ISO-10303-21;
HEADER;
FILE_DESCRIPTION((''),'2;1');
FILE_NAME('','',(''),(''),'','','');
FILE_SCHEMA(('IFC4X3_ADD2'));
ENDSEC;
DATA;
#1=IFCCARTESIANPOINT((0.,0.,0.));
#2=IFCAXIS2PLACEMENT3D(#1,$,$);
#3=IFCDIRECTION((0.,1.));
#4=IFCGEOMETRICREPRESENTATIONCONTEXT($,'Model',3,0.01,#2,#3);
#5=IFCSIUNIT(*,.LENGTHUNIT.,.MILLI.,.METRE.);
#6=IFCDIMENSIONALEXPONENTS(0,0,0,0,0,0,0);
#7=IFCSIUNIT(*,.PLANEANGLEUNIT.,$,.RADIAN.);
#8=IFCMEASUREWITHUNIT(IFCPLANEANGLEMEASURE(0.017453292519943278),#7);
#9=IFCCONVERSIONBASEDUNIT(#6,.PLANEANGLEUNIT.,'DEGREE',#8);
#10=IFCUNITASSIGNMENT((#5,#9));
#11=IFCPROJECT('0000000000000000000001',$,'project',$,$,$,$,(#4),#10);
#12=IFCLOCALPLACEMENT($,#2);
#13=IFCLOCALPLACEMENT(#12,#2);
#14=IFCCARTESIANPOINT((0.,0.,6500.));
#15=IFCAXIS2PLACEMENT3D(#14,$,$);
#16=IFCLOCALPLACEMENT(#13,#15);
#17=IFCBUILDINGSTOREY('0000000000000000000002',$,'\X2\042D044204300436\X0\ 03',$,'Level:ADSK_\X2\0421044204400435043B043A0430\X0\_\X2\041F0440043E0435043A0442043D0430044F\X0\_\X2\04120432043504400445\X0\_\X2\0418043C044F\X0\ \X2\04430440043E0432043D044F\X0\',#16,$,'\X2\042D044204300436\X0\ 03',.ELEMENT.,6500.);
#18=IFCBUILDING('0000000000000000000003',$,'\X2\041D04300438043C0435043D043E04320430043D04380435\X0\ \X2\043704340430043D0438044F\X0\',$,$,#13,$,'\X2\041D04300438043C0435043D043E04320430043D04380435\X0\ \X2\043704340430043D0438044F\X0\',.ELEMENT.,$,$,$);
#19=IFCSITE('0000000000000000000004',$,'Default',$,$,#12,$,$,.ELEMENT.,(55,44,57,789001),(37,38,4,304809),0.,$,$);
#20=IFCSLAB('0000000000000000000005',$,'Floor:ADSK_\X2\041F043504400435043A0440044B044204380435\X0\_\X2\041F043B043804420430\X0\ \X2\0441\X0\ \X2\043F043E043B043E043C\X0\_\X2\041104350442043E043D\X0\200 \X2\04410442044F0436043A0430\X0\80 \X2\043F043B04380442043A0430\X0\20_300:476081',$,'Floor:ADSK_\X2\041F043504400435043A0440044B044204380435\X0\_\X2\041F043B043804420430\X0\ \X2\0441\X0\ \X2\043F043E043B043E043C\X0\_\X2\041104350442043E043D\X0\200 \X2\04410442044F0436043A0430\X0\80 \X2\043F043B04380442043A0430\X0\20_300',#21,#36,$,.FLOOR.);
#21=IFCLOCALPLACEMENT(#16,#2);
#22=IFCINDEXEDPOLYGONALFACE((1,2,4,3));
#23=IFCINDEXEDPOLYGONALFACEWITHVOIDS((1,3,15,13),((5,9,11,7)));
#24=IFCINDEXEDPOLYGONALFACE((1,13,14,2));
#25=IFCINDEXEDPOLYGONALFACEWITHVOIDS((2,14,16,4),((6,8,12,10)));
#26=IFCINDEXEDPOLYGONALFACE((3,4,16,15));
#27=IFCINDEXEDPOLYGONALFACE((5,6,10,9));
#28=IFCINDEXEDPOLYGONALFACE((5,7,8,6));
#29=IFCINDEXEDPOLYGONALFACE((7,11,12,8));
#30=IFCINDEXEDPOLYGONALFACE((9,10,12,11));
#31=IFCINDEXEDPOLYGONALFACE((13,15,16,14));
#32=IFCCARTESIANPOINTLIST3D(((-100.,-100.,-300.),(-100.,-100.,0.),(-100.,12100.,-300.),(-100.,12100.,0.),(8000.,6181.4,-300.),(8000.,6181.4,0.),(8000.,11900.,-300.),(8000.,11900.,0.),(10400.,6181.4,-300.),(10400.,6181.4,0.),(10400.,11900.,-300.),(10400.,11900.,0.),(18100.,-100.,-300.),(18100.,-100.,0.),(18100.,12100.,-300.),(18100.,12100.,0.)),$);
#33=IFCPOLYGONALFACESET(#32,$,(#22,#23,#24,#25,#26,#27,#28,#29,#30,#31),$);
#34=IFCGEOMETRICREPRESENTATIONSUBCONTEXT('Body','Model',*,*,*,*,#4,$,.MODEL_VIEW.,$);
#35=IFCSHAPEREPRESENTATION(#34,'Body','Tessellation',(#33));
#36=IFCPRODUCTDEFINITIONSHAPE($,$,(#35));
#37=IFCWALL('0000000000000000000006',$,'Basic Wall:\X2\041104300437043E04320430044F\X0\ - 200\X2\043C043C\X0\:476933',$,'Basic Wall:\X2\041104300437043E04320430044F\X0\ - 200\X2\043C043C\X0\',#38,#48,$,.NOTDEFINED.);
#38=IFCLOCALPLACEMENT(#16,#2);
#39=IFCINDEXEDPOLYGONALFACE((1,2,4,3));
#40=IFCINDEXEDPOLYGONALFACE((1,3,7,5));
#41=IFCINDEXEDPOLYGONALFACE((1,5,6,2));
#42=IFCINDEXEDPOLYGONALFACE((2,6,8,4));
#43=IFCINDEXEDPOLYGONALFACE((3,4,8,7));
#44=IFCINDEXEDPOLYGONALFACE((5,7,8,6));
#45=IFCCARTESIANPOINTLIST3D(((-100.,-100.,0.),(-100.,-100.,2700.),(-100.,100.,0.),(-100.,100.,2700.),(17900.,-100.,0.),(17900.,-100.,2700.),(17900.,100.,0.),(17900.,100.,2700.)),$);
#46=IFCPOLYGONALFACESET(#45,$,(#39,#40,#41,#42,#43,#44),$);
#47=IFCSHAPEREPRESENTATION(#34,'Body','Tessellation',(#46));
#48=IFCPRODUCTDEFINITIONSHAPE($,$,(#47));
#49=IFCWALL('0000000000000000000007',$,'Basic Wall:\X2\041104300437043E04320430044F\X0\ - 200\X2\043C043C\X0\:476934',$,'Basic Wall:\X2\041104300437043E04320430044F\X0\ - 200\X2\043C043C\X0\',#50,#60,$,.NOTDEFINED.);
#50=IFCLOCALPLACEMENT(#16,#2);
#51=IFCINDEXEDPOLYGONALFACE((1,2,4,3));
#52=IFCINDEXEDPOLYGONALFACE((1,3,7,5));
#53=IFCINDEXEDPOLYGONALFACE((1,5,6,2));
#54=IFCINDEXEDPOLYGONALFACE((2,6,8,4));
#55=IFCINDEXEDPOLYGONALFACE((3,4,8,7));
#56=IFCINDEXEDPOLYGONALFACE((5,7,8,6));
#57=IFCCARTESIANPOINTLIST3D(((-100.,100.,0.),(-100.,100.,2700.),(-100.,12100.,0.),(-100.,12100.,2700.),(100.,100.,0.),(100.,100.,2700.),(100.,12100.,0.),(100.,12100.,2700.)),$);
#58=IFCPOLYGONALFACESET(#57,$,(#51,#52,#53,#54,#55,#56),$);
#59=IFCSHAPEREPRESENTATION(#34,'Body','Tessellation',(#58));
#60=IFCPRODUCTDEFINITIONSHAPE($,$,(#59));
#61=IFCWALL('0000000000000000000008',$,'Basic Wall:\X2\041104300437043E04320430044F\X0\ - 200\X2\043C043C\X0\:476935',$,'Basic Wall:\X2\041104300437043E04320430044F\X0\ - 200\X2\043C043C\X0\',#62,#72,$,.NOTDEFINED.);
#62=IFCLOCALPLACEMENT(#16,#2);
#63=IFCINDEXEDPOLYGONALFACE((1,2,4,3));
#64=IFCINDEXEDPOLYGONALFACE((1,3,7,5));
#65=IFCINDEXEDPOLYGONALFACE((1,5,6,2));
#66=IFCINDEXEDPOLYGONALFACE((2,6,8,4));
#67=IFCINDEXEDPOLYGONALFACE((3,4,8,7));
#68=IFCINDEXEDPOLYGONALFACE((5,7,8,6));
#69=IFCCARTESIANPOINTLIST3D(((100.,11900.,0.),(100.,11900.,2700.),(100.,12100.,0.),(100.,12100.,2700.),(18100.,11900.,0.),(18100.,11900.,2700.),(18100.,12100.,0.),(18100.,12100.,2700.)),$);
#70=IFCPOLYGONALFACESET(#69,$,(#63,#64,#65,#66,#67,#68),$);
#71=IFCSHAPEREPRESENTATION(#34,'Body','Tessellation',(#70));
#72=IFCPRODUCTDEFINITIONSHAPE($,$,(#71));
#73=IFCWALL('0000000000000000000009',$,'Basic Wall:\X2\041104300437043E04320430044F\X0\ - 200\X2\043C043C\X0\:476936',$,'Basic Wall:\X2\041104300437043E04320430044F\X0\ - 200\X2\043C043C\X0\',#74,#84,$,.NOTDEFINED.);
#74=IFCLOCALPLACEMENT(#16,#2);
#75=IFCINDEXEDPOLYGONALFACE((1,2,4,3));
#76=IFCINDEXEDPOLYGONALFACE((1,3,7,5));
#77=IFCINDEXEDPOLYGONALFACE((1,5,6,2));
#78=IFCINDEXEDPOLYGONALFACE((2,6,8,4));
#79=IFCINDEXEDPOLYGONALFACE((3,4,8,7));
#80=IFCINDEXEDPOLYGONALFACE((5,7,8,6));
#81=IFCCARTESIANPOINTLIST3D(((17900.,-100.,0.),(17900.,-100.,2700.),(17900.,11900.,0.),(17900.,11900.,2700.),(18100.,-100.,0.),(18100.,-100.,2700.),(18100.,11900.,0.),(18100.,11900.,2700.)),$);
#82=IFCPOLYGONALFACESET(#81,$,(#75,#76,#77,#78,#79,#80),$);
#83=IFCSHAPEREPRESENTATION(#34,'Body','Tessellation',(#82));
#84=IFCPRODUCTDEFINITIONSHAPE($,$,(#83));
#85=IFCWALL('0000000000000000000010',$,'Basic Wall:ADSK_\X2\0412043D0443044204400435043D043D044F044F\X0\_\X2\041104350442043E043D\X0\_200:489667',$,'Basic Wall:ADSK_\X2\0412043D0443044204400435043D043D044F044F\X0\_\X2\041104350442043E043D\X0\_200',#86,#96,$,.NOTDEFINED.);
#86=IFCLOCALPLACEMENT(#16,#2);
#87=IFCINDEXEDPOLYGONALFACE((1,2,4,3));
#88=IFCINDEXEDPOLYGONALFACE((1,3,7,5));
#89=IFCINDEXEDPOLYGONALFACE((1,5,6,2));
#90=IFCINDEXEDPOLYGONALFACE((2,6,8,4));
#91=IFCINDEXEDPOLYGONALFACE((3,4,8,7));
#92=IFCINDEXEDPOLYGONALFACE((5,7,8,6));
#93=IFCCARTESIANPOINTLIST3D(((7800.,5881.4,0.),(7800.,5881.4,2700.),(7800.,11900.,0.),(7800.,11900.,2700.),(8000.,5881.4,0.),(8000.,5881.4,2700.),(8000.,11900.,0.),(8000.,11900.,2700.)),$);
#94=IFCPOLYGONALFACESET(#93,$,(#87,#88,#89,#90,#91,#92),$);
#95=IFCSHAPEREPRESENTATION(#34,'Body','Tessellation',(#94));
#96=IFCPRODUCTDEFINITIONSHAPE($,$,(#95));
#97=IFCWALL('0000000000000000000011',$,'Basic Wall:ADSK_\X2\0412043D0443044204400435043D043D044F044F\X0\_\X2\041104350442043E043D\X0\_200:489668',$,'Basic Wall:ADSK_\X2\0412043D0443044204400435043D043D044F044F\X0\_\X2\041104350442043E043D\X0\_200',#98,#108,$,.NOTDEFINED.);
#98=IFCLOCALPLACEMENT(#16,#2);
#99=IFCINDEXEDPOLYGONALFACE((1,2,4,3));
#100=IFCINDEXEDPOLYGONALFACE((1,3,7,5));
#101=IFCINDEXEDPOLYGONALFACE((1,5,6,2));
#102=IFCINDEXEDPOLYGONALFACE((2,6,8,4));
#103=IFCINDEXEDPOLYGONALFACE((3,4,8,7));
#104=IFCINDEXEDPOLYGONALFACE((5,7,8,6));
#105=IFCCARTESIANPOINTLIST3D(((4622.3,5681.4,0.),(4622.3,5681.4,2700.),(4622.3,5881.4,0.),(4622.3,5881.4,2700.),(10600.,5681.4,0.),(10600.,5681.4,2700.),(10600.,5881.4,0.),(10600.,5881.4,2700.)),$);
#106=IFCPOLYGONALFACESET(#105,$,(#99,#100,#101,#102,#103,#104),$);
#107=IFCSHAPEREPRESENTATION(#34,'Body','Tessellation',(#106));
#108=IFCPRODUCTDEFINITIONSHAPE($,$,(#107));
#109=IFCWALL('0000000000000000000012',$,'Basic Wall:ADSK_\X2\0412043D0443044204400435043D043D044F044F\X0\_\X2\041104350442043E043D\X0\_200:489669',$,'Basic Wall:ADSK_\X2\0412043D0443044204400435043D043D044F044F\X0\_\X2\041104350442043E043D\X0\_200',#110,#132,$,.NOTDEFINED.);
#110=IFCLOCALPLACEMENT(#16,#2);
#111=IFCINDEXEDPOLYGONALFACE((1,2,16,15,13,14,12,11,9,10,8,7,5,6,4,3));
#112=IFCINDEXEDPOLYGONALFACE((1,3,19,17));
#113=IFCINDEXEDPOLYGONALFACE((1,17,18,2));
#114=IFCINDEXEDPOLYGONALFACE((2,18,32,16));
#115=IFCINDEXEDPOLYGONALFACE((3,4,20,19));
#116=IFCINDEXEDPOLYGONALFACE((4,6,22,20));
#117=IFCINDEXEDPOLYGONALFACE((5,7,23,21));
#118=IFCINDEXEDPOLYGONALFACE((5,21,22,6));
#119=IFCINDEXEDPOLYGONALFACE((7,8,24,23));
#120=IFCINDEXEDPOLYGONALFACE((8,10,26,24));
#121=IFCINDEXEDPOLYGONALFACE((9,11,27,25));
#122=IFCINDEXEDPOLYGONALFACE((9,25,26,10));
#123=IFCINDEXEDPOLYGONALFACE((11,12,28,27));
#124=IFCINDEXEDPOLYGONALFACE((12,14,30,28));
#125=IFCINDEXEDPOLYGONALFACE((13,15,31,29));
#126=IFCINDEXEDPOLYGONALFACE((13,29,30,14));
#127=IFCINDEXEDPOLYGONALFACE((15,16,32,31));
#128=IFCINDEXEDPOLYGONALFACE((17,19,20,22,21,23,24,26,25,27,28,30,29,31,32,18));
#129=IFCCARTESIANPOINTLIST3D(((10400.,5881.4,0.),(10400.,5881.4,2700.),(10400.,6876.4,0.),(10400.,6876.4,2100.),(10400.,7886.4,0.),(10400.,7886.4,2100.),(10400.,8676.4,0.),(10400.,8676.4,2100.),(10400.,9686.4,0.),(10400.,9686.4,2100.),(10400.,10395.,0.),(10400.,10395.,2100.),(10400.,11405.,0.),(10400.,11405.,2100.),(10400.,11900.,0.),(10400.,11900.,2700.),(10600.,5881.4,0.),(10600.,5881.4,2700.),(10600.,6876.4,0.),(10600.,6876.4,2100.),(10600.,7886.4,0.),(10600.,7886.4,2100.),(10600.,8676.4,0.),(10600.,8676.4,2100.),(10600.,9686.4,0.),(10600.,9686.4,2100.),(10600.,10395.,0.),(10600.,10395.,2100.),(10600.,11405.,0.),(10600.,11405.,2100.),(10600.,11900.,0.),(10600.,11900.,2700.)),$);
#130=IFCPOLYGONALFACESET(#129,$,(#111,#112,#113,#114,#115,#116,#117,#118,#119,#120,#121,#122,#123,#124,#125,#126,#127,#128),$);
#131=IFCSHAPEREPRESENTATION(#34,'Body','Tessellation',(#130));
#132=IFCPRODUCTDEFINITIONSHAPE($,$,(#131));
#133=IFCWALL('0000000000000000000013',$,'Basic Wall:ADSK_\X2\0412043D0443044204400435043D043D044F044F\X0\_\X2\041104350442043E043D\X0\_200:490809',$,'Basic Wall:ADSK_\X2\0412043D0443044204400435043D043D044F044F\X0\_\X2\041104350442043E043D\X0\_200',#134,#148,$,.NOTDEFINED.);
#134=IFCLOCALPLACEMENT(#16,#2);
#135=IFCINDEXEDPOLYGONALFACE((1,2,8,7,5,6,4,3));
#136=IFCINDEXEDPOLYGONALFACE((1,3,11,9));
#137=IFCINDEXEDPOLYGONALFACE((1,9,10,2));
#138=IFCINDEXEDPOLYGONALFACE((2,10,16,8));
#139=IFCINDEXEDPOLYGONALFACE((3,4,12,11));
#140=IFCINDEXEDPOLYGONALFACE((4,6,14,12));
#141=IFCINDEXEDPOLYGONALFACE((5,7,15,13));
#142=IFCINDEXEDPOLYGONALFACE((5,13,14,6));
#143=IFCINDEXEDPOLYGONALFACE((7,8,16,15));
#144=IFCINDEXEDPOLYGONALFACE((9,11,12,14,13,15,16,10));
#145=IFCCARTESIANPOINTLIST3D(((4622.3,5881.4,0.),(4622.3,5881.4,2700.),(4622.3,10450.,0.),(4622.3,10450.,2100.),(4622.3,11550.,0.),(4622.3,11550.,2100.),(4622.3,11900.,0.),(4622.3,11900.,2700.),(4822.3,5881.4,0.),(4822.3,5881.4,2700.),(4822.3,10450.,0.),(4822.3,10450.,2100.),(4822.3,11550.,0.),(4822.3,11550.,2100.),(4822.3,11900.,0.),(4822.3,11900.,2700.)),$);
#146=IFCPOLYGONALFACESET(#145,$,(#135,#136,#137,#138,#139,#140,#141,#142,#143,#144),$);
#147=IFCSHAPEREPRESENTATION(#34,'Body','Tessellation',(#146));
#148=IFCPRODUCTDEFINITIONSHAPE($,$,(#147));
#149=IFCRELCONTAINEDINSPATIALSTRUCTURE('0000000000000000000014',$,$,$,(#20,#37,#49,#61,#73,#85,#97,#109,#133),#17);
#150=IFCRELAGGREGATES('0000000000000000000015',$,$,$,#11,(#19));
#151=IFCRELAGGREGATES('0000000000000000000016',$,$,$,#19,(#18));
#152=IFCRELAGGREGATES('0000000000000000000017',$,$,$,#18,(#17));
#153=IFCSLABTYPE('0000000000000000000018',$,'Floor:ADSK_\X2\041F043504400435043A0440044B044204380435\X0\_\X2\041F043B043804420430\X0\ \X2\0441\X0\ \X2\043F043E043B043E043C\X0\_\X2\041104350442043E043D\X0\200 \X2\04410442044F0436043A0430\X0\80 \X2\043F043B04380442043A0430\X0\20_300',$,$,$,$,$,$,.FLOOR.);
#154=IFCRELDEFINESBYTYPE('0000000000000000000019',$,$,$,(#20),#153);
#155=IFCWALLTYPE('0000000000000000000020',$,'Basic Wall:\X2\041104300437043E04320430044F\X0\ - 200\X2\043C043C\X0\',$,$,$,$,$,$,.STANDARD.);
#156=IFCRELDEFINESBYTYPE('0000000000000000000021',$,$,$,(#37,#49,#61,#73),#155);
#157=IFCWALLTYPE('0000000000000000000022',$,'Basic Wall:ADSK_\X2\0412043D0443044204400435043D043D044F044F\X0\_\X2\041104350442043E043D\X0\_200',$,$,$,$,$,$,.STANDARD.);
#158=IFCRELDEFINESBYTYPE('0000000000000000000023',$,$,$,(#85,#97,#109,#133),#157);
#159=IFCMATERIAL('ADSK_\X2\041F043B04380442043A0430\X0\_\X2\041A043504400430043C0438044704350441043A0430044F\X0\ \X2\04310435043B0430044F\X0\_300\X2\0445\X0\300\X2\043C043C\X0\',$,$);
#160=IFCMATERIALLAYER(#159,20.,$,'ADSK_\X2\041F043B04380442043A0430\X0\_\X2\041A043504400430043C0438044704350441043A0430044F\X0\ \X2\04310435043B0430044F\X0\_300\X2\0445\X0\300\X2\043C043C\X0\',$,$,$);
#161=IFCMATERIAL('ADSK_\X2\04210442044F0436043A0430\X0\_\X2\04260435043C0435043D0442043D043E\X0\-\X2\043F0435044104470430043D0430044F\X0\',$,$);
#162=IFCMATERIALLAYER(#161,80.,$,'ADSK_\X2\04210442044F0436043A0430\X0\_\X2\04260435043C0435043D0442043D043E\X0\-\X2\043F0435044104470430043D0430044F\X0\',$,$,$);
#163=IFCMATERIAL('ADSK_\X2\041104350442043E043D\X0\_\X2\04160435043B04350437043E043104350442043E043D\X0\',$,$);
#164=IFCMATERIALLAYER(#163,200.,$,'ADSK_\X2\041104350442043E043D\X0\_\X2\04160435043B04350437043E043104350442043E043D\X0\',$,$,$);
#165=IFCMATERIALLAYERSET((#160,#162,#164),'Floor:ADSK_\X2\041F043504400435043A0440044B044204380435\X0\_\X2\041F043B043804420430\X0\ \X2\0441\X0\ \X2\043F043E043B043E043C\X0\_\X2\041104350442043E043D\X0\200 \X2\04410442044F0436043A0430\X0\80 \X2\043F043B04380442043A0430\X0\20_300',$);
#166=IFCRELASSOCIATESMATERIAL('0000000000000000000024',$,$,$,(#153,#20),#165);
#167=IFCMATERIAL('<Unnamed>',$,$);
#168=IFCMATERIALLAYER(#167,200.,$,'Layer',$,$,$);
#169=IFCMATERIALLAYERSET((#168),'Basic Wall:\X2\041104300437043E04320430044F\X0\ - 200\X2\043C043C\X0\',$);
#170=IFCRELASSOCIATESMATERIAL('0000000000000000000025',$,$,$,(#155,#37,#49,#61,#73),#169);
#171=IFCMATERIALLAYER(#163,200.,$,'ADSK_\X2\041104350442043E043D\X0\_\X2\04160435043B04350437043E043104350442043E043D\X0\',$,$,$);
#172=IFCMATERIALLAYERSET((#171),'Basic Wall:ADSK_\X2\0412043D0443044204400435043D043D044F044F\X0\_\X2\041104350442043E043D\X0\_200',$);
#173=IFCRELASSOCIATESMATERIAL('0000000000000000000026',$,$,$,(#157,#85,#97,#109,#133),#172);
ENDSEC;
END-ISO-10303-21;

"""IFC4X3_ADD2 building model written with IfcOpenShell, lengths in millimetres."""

from ifc_helpers import new_model, entity, si_unit, converted_unit, direction, frame, frame_2d, origin, origin_2d_with_axis, place, context, subcontext, project, spatial, rectangle, extrude, boolean, material, layer, layer_set, layer_usage, type_object, element, save


model = new_model("IFC4X3_ADD2")

# Units and contexts
model_context = context("Model", 3, precision=0.01, world=origin(), true_north=direction((0.0, 1.0)))
body_context = subcontext(model_context, "Body", "Model", "MODEL_VIEW")
ifc_project = project(units=[si_unit("LENGTHUNIT", "METRE", prefix="MILLI"), converted_unit("PLANEANGLEUNIT", "DEGREE", entity("IfcPlaneAngleMeasure", 0.017453292519943278), si_unit("PLANEANGLEUNIT", "RADIAN"), dimensions=[0, 0, 0, 0, 0, 0, 0])], contexts=[model_context])

# Site, building, storey
site_placement = place(None, origin())
site = spatial("IfcSite", under=ifc_project, at=site_placement, Name="Default", CompositionType="ELEMENT", RefLatitude=(55, 44, 57, 789001), RefLongitude=(37, 38, 4, 304809), RefElevation=0.0)
building_placement = place(site_placement, origin())
building = spatial("IfcBuilding", under=site, at=building_placement, Name="Наименование здания", LongName="Наименование здания", CompositionType="ELEMENT")
storey_placement = place(building_placement, frame((0.0, 0.0, 6500.0)))
storey = spatial("IfcBuildingStorey", under=building, at=storey_placement, Name="Этаж 03", ObjectType="Level:ADSK_Стрелка_Проектная_Вверх_Имя уровня", LongName="Этаж 03", CompositionType="ELEMENT", Elevation=6500.0)

# Slab, opening
ifc_material_1 = material(Name="ADSK_Плитка_Керамическая белая_300х300мм")
ifc_layer_1 = layer(ifc_material_1, 20.0, Name="ADSK_Плитка_Керамическая белая_300х300мм")
ifc_material_2 = material(Name="ADSK_Стяжка_Цементно-песчаная")
ifc_layer_2 = layer(ifc_material_2, 80.0, Name="ADSK_Стяжка_Цементно-песчаная")
ifc_material_3 = material(Name="ADSK_Бетон_Железобетон")
ifc_layer_3 = layer(ifc_material_3, 200.0, Name="ADSK_Бетон_Железобетон")
ifc_layer_set_1 = layer_set([ifc_layer_1, ifc_layer_2, ifc_layer_3], Name="Floor:ADSK_Перекрытие_Плита с полом_Бетон200 стяжка80 плитка20_300")
ifc_layer_usage = layer_usage(ifc_layer_set_1, "AXIS3", "POSITIVE", 0.0)
slab_type = type_object("IfcSlabType", Name="Floor:ADSK_Перекрытие_Плита с полом_Бетон200 стяжка80 плитка20_300", PredefinedType="FLOOR", material=ifc_layer_set_1)
slab_placement = place(storey_placement, origin())
slab = element("IfcSlab", 1, at=slab_placement, inside=storey, type_object=slab_type, material=ifc_layer_usage, Name="Floor:ADSK_Перекрытие_Плита с полом_Бетон200 стяжка80 плитка20_300:476081", ObjectType="Floor:ADSK_Перекрытие_Плита с полом_Бетон200 стяжка80 плитка20_300", PredefinedType="FLOOR", context=body_context, shape_type="SweptSolid", body=[
    boolean("DIFFERENCE", extrude(rectangle(XDim=12200.0, YDim=18200.0, at=origin_2d_with_axis()), frame((9000.0, 6000.0, 0.0), z_axis=(0.0, 0.0, -1.0), x_axis=(0.0, 1.0, 0.0)), (0.0, 0.0, 1.0), 300.0), extrude(rectangle(XDim=5718.6, YDim=2400.0, at=frame_2d((0.0, 0.0), x_axis=(1.0, 0.0))), frame((9200.0, 9040.7, -300.0), z_axis=(0.0, 0.0, 1.0), x_axis=(0.0, 1.0, 0.0)), (0.0, 0.0, 1.0), 300.0)),
])
opening_1_placement = place(slab_placement, origin())
element("IfcOpeningElement", 2, at=opening_1_placement, cuts=slab, PredefinedType="OPENING", context=body_context, shape_type="SweptSolid", body=[
    extrude(rectangle(XDim=2400.0, YDim=5718.6, at=frame_2d((0.0, 0.0), x_axis=(1.0, 0.0))), frame((9200.0, 9040.7, -300.0), z_axis=(0.0, 0.0, 1.0), x_axis=(-1.0, 0.0, 0.0)), (0.0, 0.0, 1.0), 300.0),
])

# Walls
ifc_material_4 = material(Name="<Unnamed>")
ifc_layer_4 = layer(ifc_material_4, 200.0, Name="Layer")
ifc_layer_set_2 = layer_set([ifc_layer_4], Name="Basic Wall:Базовая - 200мм")
wall_type_1 = type_object("IfcWallType", Name="Basic Wall:Базовая - 200мм", PredefinedType="STANDARD", material=ifc_layer_set_2)
wall_1_placement = place(storey_placement, frame((-100.0, 0.0, 0.0)))
element("IfcWall", 3, at=wall_1_placement, inside=storey, type_object=wall_type_1, material=ifc_layer_set_2, Name="Basic Wall:Базовая - 200мм:476933", ObjectType="Basic Wall:Базовая - 200мм", PredefinedType="NOTDEFINED", context=body_context, shape_type="SweptSolid", body=[
    extrude(rectangle(XDim=18000.0, YDim=200.0, at=frame_2d((9000.0, 0.0), x_axis=(-1.0, 0.0))), origin(), (0.0, 0.0, 1.0), 2700.0),
])
wall_2_placement = place(storey_placement, frame((0.0, 12100.0, 0.0), z_axis=(0.0, 0.0, 1.0), x_axis=(0.0, -1.0, 0.0)))
element("IfcWall", 4, at=wall_2_placement, inside=storey, type_object=wall_type_1, material=ifc_layer_set_2, Name="Basic Wall:Базовая - 200мм:476934", ObjectType="Basic Wall:Базовая - 200мм", PredefinedType="NOTDEFINED", context=body_context, shape_type="SweptSolid", body=[
    extrude(rectangle(XDim=12000.0, YDim=200.0, at=frame_2d((6000.0, 0.0), x_axis=(-1.0, 0.0))), origin(), (0.0, 0.0, 1.0), 2700.0),
])
wall_3_placement = place(storey_placement, frame((18100.0, 12000.0, 0.0), z_axis=(0.0, 0.0, 1.0), x_axis=(-1.0, 0.0, 0.0)))
element("IfcWall", 5, at=wall_3_placement, inside=storey, type_object=wall_type_1, material=ifc_layer_set_2, Name="Basic Wall:Базовая - 200мм:476935", ObjectType="Basic Wall:Базовая - 200мм", PredefinedType="NOTDEFINED", context=body_context, shape_type="SweptSolid", body=[
    extrude(rectangle(XDim=18000.0, YDim=200.0, at=frame_2d((9000.0, 0.0), x_axis=(-1.0, 0.0))), origin(), (0.0, 0.0, 1.0), 2700.0),
])
wall_4_placement = place(storey_placement, frame((18000.0, -100.0, 0.0), z_axis=(0.0, 0.0, 1.0), x_axis=(0.0, 1.0, 0.0)))
element("IfcWall", 6, at=wall_4_placement, inside=storey, type_object=wall_type_1, material=ifc_layer_set_2, Name="Basic Wall:Базовая - 200мм:476936", ObjectType="Basic Wall:Базовая - 200мм", PredefinedType="NOTDEFINED", context=body_context, shape_type="SweptSolid", body=[
    extrude(rectangle(XDim=12000.0, YDim=200.0, at=frame_2d((6000.0, 0.0), x_axis=(-1.0, 0.0))), origin(), (0.0, 0.0, 1.0), 2700.0),
])
ifc_layer_5 = layer(ifc_material_3, 200.0, Name="ADSK_Бетон_Железобетон")
ifc_layer_set_3 = layer_set([ifc_layer_5], Name="Basic Wall:ADSK_Внутренняя_Бетон_200")
wall_type_2 = type_object("IfcWallType", Name="Basic Wall:ADSK_Внутренняя_Бетон_200", PredefinedType="STANDARD", material=ifc_layer_set_3)
wall_5_placement = place(storey_placement, frame((7900.0, 5881.4, 0.0), z_axis=(0.0, 0.0, 1.0), x_axis=(0.0, 1.0, 0.0)))
element("IfcWall", 7, at=wall_5_placement, inside=storey, type_object=wall_type_2, material=ifc_layer_set_3, Name="Basic Wall:ADSK_Внутренняя_Бетон_200:489667", ObjectType="Basic Wall:ADSK_Внутренняя_Бетон_200", PredefinedType="NOTDEFINED", context=body_context, shape_type="SweptSolid", body=[
    extrude(rectangle(XDim=6018.6, YDim=200.0, at=frame_2d((3009.3, 0.0), x_axis=(-1.0, 0.0))), origin(), (0.0, 0.0, 1.0), 2700.0),
])
wall_6_placement = place(storey_placement, frame((4622.3, 5781.4, 0.0)))
element("IfcWall", 8, at=wall_6_placement, inside=storey, type_object=wall_type_2, material=ifc_layer_set_3, Name="Basic Wall:ADSK_Внутренняя_Бетон_200:489668", ObjectType="Basic Wall:ADSK_Внутренняя_Бетон_200", PredefinedType="NOTDEFINED", context=body_context, shape_type="SweptSolid", body=[
    extrude(rectangle(XDim=5977.7, YDim=200.0, at=frame_2d((2988.9, 0.0), x_axis=(-1.0, 0.0))), origin(), (0.0, 0.0, 1.0), 2700.0),
])

# Wall, openings
wall_7_placement = place(storey_placement, frame((10500.0, 5881.4, 0.0), z_axis=(0.0, 0.0, 1.0), x_axis=(0.0, 1.0, 0.0)))
wall_7 = element("IfcWall", 9, at=wall_7_placement, inside=storey, type_object=wall_type_2, material=ifc_layer_set_3, Name="Basic Wall:ADSK_Внутренняя_Бетон_200:489669", ObjectType="Basic Wall:ADSK_Внутренняя_Бетон_200", PredefinedType="NOTDEFINED", context=body_context, shape_type="SweptSolid", body=[
    extrude(rectangle(XDim=6018.6, YDim=200.0, at=frame_2d((3009.3, 0.0), x_axis=(-1.0, 0.0))), origin(), (0.0, 0.0, 1.0), 2700.0),
])
opening_2_placement = place(wall_7_placement, frame((-5881.4, 10500.0, 0.0), z_axis=(0.0, 0.0, 1.0), x_axis=(0.0, -1.0, 0.0)))
element("IfcOpeningElement", 10, at=opening_2_placement, cuts=wall_7, PredefinedType="OPENING", context=body_context, shape_type="SweptSolid", body=[
    extrude(rectangle(XDim=2100.0, YDim=1010.0, at=frame_2d((0.0, 0.0), x_axis=(1.0, 0.0))), frame((10600.0, 7381.4, 1050.0), z_axis=(-1.0, 0.0, 0.0), x_axis=(0.0, 0.0, -1.0)), (0.0, 0.0, 1.0), 200.0),
])
opening_3_placement = place(wall_7_placement, frame((-5881.4, 10500.0, 0.0), z_axis=(0.0, 0.0, 1.0), x_axis=(0.0, -1.0, 0.0)))
element("IfcOpeningElement", 11, at=opening_3_placement, cuts=wall_7, PredefinedType="OPENING", context=body_context, shape_type="SweptSolid", body=[
    extrude(rectangle(XDim=2100.0, YDim=1010.0, at=frame_2d((0.0, 0.0), x_axis=(1.0, 0.0))), frame((10600.0, 9181.4, 1050.0), z_axis=(-1.0, 0.0, 0.0), x_axis=(0.0, 0.0, -1.0)), (0.0, 0.0, 1.0), 200.0),
])
opening_4_placement = place(wall_7_placement, frame((-5881.4, 10500.0, 0.0), z_axis=(0.0, 0.0, 1.0), x_axis=(0.0, -1.0, 0.0)))
element("IfcOpeningElement", 12, at=opening_4_placement, cuts=wall_7, PredefinedType="OPENING", context=body_context, shape_type="SweptSolid", body=[
    extrude(rectangle(XDim=2100.0, YDim=1010.0, at=origin_2d_with_axis()), frame((10600.0, 10900.0, 1050.0), z_axis=(-1.0, 0.0, 0.0), x_axis=(0.0, 0.0, -1.0)), (0.0, 0.0, 1.0), 200.0),
])

# Wall, opening
wall_8_placement = place(storey_placement, frame((4722.3, 11900.0, 0.0), z_axis=(0.0, 0.0, 1.0), x_axis=(0.0, -1.0, 0.0)))
wall_8 = element("IfcWall", 13, at=wall_8_placement, inside=storey, type_object=wall_type_2, material=ifc_layer_set_3, Name="Basic Wall:ADSK_Внутренняя_Бетон_200:490809", ObjectType="Basic Wall:ADSK_Внутренняя_Бетон_200", PredefinedType="NOTDEFINED", context=body_context, shape_type="SweptSolid", body=[
    extrude(rectangle(XDim=6018.6, YDim=200.0, at=frame_2d((3009.3, 0.0), x_axis=(-1.0, 0.0))), origin(), (0.0, 0.0, 1.0), 2700.0),
])
opening_5_placement = place(wall_8_placement, frame((11900.0, -4722.3, 0.0), z_axis=(0.0, 0.0, 1.0), x_axis=(0.0, 1.0, 0.0)))
element("IfcOpeningElement", 14, at=opening_5_placement, cuts=wall_8, PredefinedType="OPENING", context=body_context, shape_type="SweptSolid", body=[
    extrude(rectangle(XDim=2100.0, YDim=1100.0, at=frame_2d((0.0, 0.0), x_axis=(0.0, 1.0))), frame((4122.3, 11000.0, 1050.0), z_axis=(1.0, 0.0, 0.0), x_axis=(0.0, -1.0, 0.0)), (0.0, 0.0, 1.0), 1200.0),
])

save(model, "model.ifc")
